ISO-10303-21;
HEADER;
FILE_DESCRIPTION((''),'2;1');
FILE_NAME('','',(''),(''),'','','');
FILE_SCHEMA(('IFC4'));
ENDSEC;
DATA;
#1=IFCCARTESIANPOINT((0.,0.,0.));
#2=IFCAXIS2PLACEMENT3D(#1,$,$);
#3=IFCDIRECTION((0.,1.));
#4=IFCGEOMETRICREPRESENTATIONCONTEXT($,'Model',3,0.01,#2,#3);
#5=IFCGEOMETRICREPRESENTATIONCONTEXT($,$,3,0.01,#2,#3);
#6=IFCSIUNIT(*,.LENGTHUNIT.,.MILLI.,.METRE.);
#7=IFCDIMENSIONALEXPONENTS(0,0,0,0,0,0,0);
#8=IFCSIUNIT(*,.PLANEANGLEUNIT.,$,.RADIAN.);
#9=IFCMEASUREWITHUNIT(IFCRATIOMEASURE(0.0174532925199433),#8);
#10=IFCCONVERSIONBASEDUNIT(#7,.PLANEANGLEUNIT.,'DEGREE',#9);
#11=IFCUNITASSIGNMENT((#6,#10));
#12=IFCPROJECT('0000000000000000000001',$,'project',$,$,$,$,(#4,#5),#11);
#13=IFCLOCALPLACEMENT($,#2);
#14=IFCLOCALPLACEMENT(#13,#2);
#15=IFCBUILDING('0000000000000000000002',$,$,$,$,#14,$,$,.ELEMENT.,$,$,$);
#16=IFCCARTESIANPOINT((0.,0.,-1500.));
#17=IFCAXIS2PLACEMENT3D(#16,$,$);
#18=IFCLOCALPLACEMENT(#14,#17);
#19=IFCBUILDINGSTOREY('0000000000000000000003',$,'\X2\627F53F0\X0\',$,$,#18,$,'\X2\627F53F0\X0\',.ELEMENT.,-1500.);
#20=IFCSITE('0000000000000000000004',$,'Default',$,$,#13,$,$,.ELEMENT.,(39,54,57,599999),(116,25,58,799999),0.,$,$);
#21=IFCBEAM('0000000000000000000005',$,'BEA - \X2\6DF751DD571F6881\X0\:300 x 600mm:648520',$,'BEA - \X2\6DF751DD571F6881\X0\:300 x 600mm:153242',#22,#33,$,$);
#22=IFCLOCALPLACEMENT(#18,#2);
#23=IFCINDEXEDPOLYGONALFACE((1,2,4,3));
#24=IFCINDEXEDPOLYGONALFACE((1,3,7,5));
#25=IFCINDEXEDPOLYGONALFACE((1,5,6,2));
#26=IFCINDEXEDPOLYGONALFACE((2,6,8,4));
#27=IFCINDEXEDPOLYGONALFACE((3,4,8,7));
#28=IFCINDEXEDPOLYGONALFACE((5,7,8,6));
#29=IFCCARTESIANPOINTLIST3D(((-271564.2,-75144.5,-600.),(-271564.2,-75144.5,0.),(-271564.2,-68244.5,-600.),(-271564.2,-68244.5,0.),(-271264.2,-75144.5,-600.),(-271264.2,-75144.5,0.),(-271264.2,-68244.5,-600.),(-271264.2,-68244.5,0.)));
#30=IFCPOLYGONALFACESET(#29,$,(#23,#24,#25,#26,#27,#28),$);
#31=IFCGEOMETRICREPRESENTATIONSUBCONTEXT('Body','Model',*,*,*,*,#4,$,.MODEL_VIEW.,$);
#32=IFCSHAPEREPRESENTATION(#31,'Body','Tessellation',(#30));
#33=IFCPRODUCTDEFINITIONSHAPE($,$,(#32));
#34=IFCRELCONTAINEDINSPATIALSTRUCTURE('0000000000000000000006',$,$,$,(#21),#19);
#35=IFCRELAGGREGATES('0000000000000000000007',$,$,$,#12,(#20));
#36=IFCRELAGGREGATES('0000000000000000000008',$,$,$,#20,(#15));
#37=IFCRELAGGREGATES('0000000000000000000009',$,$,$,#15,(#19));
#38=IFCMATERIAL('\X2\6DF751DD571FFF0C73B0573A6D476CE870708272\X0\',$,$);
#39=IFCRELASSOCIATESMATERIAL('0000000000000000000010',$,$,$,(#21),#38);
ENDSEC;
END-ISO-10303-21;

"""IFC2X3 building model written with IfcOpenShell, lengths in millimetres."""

from ifc_helpers import new_model, entity, si_unit, converted_unit, direction, frame, origin, origin_2d_with_axis, place, context, subcontext, project, spatial, rectangle, extrude, material, element, save


model = new_model("IFC2X3")

# Units and contexts
model_context = context("Model", 3, precision=0.01, world=origin(), true_north=direction((0.0, 1.0)))
context_of_model = context(None, 3, precision=0.01, world=origin(), true_north=direction((0.0, 1.0)))
body_context = subcontext(model_context, "Body", "Model", "MODEL_VIEW")
ifc_project = project(units=[si_unit("LENGTHUNIT", "METRE", prefix="MILLI"), converted_unit("PLANEANGLEUNIT", "DEGREE", entity("IfcRatioMeasure", 0.0174532925199433), si_unit("PLANEANGLEUNIT", "RADIAN"), dimensions=[0, 0, 0, 0, 0, 0, 0])], contexts=[model_context, context_of_model])

# Site, building, storey
site_placement = place(None, origin())
site = spatial("IfcSite", under=ifc_project, at=site_placement, Name="Default", CompositionType="ELEMENT", RefLatitude=(39, 54, 57, 599999), RefLongitude=(116, 25, 58, 799999), RefElevation=0.0)
building_placement = place(site_placement, origin())
building = spatial("IfcBuilding", under=site, at=building_placement, CompositionType="ELEMENT")
storey_placement = place(building_placement, frame((0.0, 0.0, -1500.0)))
storey = spatial("IfcBuildingStorey", under=building, at=storey_placement, Name="承台", LongName="承台", CompositionType="ELEMENT", Elevation=-1500.0)

# Shared definitions
ifc_material_1 = material(Name="混凝土，现场浇注灰色")

# Beam
beam_1_placement = place(storey_placement, frame((-271414.2, -68244.5, 0.0), z_axis=(0.0, 0.0, 1.0), x_axis=(0.0, -1.0, 0.0)))
element("IfcBeam", 1, at=beam_1_placement, inside=storey, material=ifc_material_1, Name="BEA - 混凝土梁:300 x 600mm:648520", ObjectType="BEA - 混凝土梁:300 x 600mm:153242", context=body_context, shape_type="SweptSolid", body=[
    extrude(rectangle(XDim=600.0, YDim=300.0, at=origin_2d_with_axis()), frame((0.0, 0.0, -300.0), z_axis=(1.0, 0.0, 0.0), x_axis=(0.0, 0.0, -1.0)), (0.0, 0.0, 1.0), 6900.0),
])

save(model, "model.ifc")
